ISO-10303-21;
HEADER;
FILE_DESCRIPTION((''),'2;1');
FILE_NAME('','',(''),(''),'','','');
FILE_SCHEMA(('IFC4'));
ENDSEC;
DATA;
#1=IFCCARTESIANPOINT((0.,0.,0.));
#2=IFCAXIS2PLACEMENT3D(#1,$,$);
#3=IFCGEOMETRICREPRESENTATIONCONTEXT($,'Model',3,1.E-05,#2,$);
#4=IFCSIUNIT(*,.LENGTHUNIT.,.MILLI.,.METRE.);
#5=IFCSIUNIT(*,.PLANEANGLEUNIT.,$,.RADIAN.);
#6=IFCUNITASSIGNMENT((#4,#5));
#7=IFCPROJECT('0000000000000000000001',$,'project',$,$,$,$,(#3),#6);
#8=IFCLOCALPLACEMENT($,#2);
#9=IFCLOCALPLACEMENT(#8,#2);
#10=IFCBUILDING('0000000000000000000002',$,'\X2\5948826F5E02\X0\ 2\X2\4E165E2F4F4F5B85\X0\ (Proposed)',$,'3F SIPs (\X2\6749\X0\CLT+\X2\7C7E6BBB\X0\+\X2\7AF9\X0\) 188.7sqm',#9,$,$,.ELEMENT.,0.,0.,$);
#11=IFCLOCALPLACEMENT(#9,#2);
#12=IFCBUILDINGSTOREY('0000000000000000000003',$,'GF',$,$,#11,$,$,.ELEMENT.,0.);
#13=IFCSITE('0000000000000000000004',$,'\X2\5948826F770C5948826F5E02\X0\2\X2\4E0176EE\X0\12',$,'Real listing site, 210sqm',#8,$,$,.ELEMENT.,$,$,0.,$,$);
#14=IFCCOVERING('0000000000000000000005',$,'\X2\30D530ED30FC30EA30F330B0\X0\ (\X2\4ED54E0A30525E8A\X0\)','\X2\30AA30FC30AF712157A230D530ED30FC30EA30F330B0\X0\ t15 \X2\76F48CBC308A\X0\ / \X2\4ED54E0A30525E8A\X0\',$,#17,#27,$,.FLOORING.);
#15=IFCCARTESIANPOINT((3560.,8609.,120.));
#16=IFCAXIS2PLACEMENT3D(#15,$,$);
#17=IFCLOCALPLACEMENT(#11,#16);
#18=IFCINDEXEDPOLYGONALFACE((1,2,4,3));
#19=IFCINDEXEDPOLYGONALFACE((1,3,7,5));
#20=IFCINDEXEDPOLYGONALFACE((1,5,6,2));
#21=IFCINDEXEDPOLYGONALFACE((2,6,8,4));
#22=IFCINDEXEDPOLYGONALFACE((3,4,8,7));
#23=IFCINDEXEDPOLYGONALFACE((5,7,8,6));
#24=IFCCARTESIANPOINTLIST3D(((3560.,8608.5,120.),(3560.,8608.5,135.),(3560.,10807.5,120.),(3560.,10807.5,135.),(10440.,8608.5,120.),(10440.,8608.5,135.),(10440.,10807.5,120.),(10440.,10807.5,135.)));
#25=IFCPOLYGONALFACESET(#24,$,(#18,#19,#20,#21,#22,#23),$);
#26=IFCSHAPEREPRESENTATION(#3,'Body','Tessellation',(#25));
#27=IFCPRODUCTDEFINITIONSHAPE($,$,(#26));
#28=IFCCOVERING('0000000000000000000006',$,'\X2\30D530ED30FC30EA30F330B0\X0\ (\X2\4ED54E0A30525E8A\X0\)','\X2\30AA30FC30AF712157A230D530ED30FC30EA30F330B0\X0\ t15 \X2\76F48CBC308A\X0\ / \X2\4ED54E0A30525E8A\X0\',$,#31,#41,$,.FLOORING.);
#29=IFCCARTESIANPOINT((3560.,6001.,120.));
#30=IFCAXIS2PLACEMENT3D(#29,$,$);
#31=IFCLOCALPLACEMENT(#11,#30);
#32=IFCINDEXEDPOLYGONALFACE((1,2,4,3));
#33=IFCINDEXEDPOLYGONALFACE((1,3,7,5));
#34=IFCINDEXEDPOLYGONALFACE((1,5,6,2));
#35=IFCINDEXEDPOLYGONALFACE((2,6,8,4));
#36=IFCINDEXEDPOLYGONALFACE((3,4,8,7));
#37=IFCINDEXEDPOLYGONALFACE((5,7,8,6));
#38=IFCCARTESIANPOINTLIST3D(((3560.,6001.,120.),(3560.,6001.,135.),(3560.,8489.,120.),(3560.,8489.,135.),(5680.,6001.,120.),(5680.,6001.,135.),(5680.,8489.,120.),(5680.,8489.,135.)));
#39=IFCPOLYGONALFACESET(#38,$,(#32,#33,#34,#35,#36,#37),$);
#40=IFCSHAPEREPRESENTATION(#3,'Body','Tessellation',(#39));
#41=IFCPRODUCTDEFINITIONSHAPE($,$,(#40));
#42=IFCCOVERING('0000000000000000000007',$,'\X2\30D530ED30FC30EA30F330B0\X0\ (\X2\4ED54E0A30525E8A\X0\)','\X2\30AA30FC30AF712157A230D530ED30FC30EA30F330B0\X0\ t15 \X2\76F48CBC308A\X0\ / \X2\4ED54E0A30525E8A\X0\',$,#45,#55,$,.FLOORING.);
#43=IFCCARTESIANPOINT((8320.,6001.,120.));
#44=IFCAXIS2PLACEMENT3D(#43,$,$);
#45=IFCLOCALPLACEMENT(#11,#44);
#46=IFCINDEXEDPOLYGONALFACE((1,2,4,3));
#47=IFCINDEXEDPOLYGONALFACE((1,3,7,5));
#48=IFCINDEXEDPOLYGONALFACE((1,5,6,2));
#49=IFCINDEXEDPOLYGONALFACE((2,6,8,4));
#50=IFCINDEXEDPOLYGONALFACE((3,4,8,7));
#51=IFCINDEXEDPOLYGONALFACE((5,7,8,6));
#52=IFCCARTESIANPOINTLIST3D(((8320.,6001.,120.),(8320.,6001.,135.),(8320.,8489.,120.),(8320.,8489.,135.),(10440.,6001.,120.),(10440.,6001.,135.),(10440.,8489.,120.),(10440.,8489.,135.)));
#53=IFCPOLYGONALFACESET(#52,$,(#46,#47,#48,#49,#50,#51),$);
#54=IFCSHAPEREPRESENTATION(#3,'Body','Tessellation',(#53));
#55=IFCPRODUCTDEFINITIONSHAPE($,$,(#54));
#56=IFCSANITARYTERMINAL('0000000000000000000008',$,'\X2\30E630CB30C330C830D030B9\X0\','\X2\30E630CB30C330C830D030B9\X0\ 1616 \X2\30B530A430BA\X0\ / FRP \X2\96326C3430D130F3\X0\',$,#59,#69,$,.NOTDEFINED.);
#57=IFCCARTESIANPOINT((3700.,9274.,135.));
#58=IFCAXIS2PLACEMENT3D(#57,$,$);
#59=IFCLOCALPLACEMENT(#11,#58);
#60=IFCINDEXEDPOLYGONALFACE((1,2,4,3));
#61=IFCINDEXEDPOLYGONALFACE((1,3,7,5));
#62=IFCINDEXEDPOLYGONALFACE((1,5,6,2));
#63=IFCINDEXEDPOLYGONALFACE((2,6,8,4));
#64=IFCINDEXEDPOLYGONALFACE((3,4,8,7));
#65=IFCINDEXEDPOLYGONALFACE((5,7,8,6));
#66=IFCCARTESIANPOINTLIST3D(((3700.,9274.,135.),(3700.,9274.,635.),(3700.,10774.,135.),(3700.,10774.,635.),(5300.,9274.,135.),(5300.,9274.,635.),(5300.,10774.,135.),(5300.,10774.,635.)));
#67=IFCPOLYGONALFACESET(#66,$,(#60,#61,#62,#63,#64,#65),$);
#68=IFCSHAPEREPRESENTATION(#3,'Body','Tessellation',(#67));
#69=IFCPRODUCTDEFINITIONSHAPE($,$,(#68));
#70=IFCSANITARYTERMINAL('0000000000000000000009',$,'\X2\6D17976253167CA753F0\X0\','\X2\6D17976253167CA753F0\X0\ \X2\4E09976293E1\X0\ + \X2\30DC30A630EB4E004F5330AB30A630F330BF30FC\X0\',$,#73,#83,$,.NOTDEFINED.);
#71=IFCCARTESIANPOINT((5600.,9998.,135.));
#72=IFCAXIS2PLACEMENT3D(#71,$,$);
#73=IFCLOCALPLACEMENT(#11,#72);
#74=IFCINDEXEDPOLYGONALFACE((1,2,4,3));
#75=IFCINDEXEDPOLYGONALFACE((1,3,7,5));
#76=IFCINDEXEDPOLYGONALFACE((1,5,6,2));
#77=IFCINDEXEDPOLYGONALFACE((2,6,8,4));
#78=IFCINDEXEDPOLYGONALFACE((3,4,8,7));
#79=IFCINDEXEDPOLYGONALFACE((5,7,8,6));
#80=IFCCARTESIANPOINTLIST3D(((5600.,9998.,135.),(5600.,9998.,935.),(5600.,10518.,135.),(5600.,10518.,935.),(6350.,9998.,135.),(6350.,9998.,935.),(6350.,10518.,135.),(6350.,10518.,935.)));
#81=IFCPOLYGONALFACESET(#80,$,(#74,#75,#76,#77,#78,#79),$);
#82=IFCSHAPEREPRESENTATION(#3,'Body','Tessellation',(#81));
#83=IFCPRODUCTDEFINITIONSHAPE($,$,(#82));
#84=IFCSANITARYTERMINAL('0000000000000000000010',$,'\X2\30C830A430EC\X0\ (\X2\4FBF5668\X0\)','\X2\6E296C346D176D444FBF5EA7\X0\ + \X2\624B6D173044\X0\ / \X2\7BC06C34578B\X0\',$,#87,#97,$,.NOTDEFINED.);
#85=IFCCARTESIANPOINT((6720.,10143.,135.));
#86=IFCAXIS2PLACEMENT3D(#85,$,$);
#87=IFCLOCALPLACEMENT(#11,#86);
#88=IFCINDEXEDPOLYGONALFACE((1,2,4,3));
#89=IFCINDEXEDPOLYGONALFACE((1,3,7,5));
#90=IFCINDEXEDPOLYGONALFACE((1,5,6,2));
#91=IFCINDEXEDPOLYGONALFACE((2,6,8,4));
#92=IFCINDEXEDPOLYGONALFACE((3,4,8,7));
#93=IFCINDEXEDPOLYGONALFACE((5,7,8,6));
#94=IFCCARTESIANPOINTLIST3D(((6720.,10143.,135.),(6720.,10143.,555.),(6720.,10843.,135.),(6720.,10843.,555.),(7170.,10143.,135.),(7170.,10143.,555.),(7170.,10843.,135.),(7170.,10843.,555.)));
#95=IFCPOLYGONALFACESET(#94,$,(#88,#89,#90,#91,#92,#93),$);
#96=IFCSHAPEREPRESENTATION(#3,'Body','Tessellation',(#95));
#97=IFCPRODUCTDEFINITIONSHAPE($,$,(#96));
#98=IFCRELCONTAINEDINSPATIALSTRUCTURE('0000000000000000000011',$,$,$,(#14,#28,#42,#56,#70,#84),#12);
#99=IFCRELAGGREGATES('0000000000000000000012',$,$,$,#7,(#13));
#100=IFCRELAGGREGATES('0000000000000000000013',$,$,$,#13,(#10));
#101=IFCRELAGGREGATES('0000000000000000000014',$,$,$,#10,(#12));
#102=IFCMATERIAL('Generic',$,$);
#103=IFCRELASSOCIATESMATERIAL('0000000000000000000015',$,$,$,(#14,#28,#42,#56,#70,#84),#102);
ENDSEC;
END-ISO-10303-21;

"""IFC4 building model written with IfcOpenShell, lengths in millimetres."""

from ifc_helpers import new_model, si_unit, frame, frame_2d, origin, place, context, project, spatial, rectangle, extrude, material, element, save


model = new_model("IFC4")

# Units and contexts
model_context = context("Model", 3, precision=1e-05, world=origin())
ifc_project = project(units=[si_unit("LENGTHUNIT", "METRE", prefix="MILLI"), si_unit("PLANEANGLEUNIT", "RADIAN")], contexts=[model_context])

# Site, building, storey
site_placement = place(None, origin())
site = spatial("IfcSite", under=ifc_project, at=site_placement, Name="奈良県奈良市2丁目12", ObjectType="Real listing site, 210sqm", CompositionType="ELEMENT", RefElevation=0.0)
building_placement = place(site_placement, origin())
building = spatial("IfcBuilding", under=site, at=building_placement, Name="奈良市 2世帯住宅 (Proposed)", ObjectType="3F SIPs (杉CLT+籾殻+竹) 188.7sqm", CompositionType="ELEMENT", ElevationOfRefHeight=0.0, ElevationOfTerrain=0.0)
storey_placement = place(building_placement, origin())
storey = spatial("IfcBuildingStorey", under=building, at=storey_placement, Name="GF", CompositionType="ELEMENT", Elevation=0.0)

# Coverings
ifc_material_1 = material(Name="Generic")
covering_1_placement = place(storey_placement, frame((3560.0, 8609.0, 120.0)))
element("IfcCovering", 1, at=covering_1_placement, inside=storey, material=ifc_material_1, Name="フローリング (仕上げ床)", Description="オーク無垢フローリング t15 直貼り / 仕上げ床", PredefinedType="FLOORING", context=model_context, shape_type="SweptSolid", body=[
    extrude(rectangle(XDim=6880.0, YDim=2199.0, at=frame_2d((3440.0, 1099.0))), frame((3560.0, 8609.0, 120.0)), (0.0, 0.0, 1.0), 15.0),
])
covering_2_placement = place(storey_placement, frame((3560.0, 6001.0, 120.0)))
element("IfcCovering", 2, at=covering_2_placement, inside=storey, material=ifc_material_1, Name="フローリング (仕上げ床)", Description="オーク無垢フローリング t15 直貼り / 仕上げ床", PredefinedType="FLOORING", context=model_context, shape_type="SweptSolid", body=[
    extrude(rectangle(XDim=2120.0, YDim=2488.0, at=frame_2d((1060.0, 1244.0))), frame((3560.0, 6001.0, 120.0)), (0.0, 0.0, 1.0), 15.0),
])
covering_3_placement = place(storey_placement, frame((8320.0, 6001.0, 120.0)))
element("IfcCovering", 3, at=covering_3_placement, inside=storey, material=ifc_material_1, Name="フローリング (仕上げ床)", Description="オーク無垢フローリング t15 直貼り / 仕上げ床", PredefinedType="FLOORING", context=model_context, shape_type="SweptSolid", body=[
    extrude(rectangle(XDim=2120.0, YDim=2488.0, at=frame_2d((1060.0, 1244.0))), frame((8320.0, 6001.0, 120.0)), (0.0, 0.0, 1.0), 15.0),
])

# Sanitary terminals
sanitary_terminal_1_placement = place(storey_placement, frame((3700.0, 9274.0, 135.0)))
element("IfcSanitaryTerminal", 4, at=sanitary_terminal_1_placement, inside=storey, material=ifc_material_1, Name="ユニットバス", Description="ユニットバス 1616 サイズ / FRP 防水パン", PredefinedType="NOTDEFINED", context=model_context, shape_type="SweptSolid", body=[
    extrude(rectangle(XDim=1600.0, YDim=1500.0, at=frame_2d((800.0, 750.0))), frame((3700.0, 9274.0, 135.0)), (0.0, 0.0, 1.0), 500.0),
])
sanitary_terminal_2_placement = place(storey_placement, frame((5600.0, 9998.0, 135.0)))
element("IfcSanitaryTerminal", 5, at=sanitary_terminal_2_placement, inside=storey, material=ifc_material_1, Name="洗面化粧台", Description="洗面化粧台 三面鏡 + ボウル一体カウンター", PredefinedType="NOTDEFINED", context=model_context, shape_type="SweptSolid", body=[
    extrude(rectangle(XDim=750.0, YDim=520.0, at=frame_2d((375.0, 260.0))), frame((5600.0, 9998.0, 135.0)), (0.0, 0.0, 1.0), 800.0),
])
sanitary_terminal_3_placement = place(storey_placement, frame((6720.0, 10143.0, 135.0)))
element("IfcSanitaryTerminal", 6, at=sanitary_terminal_3_placement, inside=storey, material=ifc_material_1, Name="トイレ (便器)", Description="温水洗浄便座 + 手洗い / 節水型", PredefinedType="NOTDEFINED", context=model_context, shape_type="SweptSolid", body=[
    extrude(rectangle(XDim=450.0, YDim=700.0, at=frame_2d((225.0, 350.0))), frame((6720.0, 10143.0, 135.0)), (0.0, 0.0, 1.0), 420.0),
])

save(model, "model.ifc")
